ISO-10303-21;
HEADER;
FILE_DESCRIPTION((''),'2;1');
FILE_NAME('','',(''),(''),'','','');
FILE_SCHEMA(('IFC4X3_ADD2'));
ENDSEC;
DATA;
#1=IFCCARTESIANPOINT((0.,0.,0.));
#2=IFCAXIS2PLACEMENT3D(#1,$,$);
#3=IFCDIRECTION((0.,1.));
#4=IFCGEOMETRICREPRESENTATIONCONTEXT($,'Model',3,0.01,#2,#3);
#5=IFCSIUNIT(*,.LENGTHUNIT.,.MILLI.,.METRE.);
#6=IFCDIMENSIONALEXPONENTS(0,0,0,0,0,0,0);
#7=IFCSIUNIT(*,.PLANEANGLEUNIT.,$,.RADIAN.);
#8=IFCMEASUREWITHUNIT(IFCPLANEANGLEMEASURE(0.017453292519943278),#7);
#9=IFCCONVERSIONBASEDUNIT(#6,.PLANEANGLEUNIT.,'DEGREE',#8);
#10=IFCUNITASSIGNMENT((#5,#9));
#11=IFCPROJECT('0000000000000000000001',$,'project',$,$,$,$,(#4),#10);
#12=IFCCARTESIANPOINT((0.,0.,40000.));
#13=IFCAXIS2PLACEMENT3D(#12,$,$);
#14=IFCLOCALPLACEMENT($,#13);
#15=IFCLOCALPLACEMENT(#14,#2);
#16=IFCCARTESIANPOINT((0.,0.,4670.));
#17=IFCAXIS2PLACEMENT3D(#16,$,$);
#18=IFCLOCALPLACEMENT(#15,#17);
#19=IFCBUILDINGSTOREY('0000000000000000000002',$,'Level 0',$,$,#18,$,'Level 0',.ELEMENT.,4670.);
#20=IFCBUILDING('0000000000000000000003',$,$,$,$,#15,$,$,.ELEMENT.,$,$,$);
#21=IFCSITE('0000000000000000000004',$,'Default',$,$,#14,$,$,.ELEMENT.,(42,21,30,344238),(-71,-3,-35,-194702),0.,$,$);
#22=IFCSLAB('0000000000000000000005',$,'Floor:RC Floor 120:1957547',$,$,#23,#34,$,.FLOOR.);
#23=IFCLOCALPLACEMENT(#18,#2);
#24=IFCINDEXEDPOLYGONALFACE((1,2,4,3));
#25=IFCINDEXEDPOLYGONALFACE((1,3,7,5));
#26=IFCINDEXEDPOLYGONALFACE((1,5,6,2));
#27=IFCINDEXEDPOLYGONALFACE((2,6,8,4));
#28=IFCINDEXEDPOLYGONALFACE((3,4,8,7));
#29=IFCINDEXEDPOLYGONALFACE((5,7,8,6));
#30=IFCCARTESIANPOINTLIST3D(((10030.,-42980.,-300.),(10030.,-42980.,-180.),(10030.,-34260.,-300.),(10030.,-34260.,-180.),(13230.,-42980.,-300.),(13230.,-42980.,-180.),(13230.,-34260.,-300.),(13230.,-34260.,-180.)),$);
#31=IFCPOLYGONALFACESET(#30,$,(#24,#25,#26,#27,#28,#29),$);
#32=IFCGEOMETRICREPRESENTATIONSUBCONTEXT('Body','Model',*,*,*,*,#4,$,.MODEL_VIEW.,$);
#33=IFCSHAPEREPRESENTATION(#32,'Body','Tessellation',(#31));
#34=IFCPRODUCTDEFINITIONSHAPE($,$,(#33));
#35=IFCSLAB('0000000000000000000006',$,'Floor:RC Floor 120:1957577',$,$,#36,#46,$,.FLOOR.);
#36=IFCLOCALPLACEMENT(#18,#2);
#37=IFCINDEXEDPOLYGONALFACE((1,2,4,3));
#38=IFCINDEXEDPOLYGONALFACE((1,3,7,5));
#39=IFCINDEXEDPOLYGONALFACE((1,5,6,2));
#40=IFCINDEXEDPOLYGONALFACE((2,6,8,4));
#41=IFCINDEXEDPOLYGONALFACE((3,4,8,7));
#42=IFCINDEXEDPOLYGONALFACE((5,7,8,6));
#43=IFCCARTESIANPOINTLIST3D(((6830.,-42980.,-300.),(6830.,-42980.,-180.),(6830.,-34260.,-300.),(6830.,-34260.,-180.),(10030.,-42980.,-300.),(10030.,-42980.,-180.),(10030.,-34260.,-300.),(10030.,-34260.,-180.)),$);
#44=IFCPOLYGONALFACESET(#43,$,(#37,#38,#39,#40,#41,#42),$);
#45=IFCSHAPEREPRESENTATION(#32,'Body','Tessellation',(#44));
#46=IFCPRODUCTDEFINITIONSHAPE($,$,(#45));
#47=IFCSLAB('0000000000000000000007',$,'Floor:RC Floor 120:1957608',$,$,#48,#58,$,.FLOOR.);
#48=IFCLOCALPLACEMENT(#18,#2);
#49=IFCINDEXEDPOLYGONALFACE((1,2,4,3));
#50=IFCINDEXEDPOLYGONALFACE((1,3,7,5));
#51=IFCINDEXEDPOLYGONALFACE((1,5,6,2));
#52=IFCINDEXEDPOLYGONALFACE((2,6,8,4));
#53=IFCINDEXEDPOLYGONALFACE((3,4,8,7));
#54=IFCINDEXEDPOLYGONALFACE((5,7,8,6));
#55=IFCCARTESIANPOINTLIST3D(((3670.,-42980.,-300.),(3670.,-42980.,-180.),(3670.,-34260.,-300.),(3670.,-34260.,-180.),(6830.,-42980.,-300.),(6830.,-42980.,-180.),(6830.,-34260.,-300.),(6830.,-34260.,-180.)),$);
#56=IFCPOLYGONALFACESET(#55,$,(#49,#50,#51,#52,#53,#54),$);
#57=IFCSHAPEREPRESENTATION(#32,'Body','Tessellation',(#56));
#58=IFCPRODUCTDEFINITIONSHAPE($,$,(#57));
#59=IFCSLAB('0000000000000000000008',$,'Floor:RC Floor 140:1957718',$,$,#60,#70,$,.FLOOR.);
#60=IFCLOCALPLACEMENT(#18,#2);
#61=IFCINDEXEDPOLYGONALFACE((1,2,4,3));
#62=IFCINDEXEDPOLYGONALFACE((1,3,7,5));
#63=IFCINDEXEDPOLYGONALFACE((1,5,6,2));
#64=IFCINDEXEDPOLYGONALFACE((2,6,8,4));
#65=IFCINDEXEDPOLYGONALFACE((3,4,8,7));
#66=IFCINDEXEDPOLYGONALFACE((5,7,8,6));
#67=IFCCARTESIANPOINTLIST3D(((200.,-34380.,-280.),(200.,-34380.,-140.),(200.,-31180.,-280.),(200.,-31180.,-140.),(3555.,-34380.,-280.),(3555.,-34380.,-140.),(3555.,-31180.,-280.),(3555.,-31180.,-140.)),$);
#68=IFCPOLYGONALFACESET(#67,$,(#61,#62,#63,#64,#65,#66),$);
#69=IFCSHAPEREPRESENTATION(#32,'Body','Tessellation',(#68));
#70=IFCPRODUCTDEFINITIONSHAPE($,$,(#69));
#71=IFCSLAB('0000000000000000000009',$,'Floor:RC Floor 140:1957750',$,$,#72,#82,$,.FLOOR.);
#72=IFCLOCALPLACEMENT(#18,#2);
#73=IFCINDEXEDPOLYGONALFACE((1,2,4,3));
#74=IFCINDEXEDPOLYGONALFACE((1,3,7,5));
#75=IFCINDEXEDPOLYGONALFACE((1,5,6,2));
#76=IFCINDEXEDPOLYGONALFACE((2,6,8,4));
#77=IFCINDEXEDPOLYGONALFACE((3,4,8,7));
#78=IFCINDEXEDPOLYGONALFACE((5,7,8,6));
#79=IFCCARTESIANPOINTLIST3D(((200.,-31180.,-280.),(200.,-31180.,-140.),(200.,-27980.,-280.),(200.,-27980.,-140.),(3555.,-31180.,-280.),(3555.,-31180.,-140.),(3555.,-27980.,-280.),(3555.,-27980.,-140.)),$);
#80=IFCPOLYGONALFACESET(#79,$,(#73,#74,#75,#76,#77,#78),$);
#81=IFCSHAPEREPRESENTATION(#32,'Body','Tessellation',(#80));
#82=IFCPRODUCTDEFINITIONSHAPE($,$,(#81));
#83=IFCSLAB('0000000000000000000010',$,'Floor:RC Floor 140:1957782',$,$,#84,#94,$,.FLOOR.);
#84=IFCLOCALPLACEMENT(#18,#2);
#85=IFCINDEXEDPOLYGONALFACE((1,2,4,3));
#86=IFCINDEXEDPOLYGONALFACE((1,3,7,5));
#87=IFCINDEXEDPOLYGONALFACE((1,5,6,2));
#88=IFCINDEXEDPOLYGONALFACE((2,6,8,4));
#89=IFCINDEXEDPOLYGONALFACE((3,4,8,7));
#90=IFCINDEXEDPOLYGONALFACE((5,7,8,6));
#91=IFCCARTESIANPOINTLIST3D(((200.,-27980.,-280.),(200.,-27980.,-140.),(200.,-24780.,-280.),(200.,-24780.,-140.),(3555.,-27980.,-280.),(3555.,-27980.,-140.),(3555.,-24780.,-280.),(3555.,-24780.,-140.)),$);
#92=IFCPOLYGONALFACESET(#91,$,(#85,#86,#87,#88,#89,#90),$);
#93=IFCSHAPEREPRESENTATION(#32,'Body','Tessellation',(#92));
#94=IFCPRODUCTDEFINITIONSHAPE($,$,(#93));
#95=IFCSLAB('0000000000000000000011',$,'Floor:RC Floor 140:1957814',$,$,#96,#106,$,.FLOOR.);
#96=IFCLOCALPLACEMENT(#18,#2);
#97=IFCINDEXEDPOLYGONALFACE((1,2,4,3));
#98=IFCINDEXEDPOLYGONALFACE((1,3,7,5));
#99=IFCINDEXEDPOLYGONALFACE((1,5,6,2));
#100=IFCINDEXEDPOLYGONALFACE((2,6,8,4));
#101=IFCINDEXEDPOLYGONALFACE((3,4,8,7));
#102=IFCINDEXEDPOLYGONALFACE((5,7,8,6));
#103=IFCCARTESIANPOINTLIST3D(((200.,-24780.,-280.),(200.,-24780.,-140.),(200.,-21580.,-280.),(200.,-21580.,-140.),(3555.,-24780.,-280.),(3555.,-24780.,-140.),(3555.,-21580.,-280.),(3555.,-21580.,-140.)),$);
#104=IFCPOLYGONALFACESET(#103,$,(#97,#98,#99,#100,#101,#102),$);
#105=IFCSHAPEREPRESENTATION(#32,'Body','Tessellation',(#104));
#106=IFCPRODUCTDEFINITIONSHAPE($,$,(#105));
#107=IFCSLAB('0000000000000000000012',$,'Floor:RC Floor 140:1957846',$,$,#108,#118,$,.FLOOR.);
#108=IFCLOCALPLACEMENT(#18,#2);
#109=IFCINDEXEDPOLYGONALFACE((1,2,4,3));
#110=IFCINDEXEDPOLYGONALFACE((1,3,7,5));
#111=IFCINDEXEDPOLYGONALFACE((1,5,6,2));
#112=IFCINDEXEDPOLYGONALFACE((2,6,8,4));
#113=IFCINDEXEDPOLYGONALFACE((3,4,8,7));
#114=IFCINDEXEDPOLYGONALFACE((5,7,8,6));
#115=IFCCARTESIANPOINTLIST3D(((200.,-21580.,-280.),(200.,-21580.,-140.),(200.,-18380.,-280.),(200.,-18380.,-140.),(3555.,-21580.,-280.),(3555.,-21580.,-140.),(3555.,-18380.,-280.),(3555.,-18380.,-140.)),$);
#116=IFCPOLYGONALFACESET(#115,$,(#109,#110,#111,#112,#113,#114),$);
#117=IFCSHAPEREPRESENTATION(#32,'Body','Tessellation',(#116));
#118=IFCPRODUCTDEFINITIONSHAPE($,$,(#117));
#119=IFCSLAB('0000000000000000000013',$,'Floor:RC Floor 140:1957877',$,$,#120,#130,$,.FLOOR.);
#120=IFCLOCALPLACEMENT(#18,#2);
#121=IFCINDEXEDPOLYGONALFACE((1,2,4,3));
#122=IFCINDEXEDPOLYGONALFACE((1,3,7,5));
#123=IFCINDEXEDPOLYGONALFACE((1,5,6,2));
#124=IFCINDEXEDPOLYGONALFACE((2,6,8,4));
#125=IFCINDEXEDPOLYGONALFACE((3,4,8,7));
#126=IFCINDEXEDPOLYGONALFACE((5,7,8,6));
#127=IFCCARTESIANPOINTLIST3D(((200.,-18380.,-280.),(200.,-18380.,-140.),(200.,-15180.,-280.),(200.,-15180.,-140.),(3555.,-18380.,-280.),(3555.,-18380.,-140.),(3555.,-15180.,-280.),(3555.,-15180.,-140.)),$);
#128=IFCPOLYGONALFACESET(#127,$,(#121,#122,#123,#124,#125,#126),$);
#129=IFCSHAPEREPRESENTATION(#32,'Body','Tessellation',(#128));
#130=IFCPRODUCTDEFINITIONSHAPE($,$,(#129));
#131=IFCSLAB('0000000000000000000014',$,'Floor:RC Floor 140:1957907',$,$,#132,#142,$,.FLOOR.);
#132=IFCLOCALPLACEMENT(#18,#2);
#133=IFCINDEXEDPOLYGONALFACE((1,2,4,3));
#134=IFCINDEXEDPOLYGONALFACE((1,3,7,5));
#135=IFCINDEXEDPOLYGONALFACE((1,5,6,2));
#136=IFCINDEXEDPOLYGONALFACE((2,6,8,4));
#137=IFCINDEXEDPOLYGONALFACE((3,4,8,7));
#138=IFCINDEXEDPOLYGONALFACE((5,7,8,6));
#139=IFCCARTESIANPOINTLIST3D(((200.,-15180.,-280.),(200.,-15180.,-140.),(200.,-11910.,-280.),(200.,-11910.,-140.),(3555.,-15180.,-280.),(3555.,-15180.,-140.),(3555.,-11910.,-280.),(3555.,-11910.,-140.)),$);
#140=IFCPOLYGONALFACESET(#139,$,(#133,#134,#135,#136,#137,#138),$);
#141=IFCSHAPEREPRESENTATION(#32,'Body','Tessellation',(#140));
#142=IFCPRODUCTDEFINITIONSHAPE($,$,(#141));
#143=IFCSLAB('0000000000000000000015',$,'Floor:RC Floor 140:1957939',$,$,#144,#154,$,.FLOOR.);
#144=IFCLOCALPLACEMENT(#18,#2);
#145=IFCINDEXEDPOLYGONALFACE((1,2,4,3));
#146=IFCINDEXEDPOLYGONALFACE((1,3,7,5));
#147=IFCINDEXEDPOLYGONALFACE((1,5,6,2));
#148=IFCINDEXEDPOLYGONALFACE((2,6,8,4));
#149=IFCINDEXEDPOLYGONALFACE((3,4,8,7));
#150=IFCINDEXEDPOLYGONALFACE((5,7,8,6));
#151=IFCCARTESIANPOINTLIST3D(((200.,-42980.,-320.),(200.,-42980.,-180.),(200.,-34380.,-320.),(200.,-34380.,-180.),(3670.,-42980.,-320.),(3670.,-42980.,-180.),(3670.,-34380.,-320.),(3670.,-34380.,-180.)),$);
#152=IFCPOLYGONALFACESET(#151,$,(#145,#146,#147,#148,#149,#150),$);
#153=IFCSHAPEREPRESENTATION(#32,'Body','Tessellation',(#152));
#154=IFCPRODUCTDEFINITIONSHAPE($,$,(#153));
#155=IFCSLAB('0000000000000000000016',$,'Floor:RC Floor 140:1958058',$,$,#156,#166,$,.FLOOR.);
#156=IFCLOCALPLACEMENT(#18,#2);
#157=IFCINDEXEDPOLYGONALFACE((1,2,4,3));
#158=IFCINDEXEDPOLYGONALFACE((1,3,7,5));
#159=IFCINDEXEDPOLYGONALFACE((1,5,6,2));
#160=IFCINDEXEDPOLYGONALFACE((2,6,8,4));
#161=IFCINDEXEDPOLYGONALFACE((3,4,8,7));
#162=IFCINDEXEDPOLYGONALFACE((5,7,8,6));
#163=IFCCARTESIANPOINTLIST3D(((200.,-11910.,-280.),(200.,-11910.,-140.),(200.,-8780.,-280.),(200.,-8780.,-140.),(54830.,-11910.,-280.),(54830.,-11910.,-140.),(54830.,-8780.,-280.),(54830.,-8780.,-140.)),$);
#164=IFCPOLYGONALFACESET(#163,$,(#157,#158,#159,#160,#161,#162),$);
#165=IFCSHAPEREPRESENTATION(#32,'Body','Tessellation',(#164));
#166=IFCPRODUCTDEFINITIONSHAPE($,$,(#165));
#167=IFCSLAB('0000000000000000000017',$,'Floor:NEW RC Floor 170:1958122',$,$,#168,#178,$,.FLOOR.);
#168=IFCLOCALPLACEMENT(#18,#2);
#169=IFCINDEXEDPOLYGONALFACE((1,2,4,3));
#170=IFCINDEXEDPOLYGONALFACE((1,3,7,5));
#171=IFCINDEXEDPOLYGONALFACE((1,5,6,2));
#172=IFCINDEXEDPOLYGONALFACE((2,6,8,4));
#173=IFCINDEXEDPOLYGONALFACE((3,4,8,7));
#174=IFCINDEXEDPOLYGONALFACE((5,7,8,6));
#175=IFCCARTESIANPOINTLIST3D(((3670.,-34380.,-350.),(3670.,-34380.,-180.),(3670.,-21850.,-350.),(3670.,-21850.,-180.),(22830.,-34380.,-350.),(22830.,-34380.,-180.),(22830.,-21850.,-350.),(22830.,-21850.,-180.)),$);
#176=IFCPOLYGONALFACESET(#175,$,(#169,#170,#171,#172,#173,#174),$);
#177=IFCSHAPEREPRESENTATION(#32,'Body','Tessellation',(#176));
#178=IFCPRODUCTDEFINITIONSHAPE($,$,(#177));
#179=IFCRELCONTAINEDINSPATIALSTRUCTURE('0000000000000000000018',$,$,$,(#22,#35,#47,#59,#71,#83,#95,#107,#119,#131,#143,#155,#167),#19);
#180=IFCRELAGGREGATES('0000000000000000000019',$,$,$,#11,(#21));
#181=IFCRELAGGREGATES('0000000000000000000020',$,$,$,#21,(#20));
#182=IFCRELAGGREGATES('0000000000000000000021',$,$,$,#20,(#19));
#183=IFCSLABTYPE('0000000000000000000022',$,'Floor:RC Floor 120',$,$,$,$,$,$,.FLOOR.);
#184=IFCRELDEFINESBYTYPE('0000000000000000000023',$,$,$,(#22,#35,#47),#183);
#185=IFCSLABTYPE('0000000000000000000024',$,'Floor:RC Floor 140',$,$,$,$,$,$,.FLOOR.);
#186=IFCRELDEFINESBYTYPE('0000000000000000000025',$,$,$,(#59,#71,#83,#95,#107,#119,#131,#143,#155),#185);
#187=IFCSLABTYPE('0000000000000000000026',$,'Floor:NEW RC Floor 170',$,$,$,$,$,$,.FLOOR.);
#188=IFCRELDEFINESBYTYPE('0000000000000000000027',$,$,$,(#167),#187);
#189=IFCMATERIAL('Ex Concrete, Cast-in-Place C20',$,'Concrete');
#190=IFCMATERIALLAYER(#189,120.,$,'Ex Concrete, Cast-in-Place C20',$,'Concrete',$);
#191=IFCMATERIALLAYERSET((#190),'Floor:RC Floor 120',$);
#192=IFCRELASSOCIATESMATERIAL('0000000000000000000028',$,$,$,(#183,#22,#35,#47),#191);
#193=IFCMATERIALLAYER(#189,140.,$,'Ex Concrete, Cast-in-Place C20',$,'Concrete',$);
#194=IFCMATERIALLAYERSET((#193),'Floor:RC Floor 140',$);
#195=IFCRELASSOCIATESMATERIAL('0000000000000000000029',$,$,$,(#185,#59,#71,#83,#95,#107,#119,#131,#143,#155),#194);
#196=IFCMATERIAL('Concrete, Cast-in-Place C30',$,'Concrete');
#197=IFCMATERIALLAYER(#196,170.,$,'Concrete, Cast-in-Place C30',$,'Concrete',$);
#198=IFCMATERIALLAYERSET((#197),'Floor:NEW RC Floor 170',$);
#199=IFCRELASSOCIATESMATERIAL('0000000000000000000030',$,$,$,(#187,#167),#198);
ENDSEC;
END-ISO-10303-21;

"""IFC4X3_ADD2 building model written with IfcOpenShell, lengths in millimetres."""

from ifc_helpers import new_model, entity, si_unit, converted_unit, direction, frame, frame_2d, origin, origin_2d_with_axis, place, context, subcontext, project, spatial, rectangle, extrude, material, layer, layer_set, layer_usage, type_object, element, save


model = new_model("IFC4X3_ADD2")

# Units and contexts
model_context = context("Model", 3, precision=0.01, world=origin(), true_north=direction((0.0, 1.0)))
body_context = subcontext(model_context, "Body", "Model", "MODEL_VIEW")
ifc_project = project(units=[si_unit("LENGTHUNIT", "METRE", prefix="MILLI"), converted_unit("PLANEANGLEUNIT", "DEGREE", entity("IfcPlaneAngleMeasure", 0.017453292519943278), si_unit("PLANEANGLEUNIT", "RADIAN"), dimensions=[0, 0, 0, 0, 0, 0, 0])], contexts=[model_context])

# Site, building, storey
site_placement = place(None, frame((0.0, 0.0, 40000.0)))
site = spatial("IfcSite", under=ifc_project, at=site_placement, Name="Default", CompositionType="ELEMENT", RefLatitude=(42, 21, 30, 344238), RefLongitude=(-71, -3, -35, -194702), RefElevation=0.0)
building_placement = place(site_placement, origin())
building = spatial("IfcBuilding", under=site, at=building_placement, CompositionType="ELEMENT")
storey_placement = place(building_placement, frame((0.0, 0.0, 4670.0)))
storey = spatial("IfcBuildingStorey", under=building, at=storey_placement, Name="Level 0", LongName="Level 0", CompositionType="ELEMENT", Elevation=4670.0)

# Slabs
ifc_material_1 = material(Name="Ex Concrete, Cast-in-Place C20", Category="Concrete")
ifc_layer_1 = layer(ifc_material_1, 120.0, Name="Ex Concrete, Cast-in-Place C20", Category="Concrete")
ifc_layer_set_1 = layer_set([ifc_layer_1], Name="Floor:RC Floor 120")
slab_type_1 = type_object("IfcSlabType", Name="Floor:RC Floor 120", PredefinedType="FLOOR", material=ifc_layer_set_1)
ifc_layer_usage_1 = layer_usage(ifc_layer_set_1, "AXIS3", "POSITIVE", 0.0)
slab_1_placement = place(storey_placement, origin())
element("IfcSlab", 1, at=slab_1_placement, inside=storey, type_object=slab_type_1, material=ifc_layer_usage_1, Name="Floor:RC Floor 120:1957547", PredefinedType="FLOOR", context=body_context, shape_type="SweptSolid", body=[
    extrude(rectangle(XDim=8720.0, YDim=3200.0, at=frame_2d((0.0, 0.0), x_axis=(1.0, 0.0))), frame((11630.0, -38620.0, -180.0), z_axis=(0.0, 0.0, -1.0), x_axis=(0.0, 1.0, 0.0)), (0.0, 0.0, 1.0), 120.0),
])
ifc_layer_usage_2 = layer_usage(ifc_layer_set_1, "AXIS3", "POSITIVE", 0.0)
slab_2_placement = place(storey_placement, origin())
element("IfcSlab", 2, at=slab_2_placement, inside=storey, type_object=slab_type_1, material=ifc_layer_usage_2, Name="Floor:RC Floor 120:1957577", PredefinedType="FLOOR", context=body_context, shape_type="SweptSolid", body=[
    extrude(rectangle(XDim=8720.0, YDim=3200.0, at=frame_2d((0.0, 0.0), x_axis=(1.0, 0.0))), frame((8430.0, -38620.0, -180.0), z_axis=(0.0, 0.0, -1.0), x_axis=(0.0, 1.0, 0.0)), (0.0, 0.0, 1.0), 120.0),
])
ifc_layer_usage_3 = layer_usage(ifc_layer_set_1, "AXIS3", "POSITIVE", 0.0)
slab_3_placement = place(storey_placement, origin())
element("IfcSlab", 3, at=slab_3_placement, inside=storey, type_object=slab_type_1, material=ifc_layer_usage_3, Name="Floor:RC Floor 120:1957608", PredefinedType="FLOOR", context=body_context, shape_type="SweptSolid", body=[
    extrude(rectangle(XDim=8720.0, YDim=3160.0, at=frame_2d((0.0, 0.0), x_axis=(1.0, 0.0))), frame((5250.0, -38620.0, -180.0), z_axis=(0.0, 0.0, -1.0), x_axis=(0.0, 1.0, 0.0)), (0.0, 0.0, 1.0), 120.0),
])
ifc_layer_2 = layer(ifc_material_1, 140.0, Name="Ex Concrete, Cast-in-Place C20", Category="Concrete")
ifc_layer_set_2 = layer_set([ifc_layer_2], Name="Floor:RC Floor 140")
ifc_layer_usage_4 = layer_usage(ifc_layer_set_2, "AXIS3", "POSITIVE", 0.0)
slab_type_2 = type_object("IfcSlabType", Name="Floor:RC Floor 140", PredefinedType="FLOOR", material=ifc_layer_set_2)
slab_4_placement = place(storey_placement, origin())
element("IfcSlab", 4, at=slab_4_placement, inside=storey, type_object=slab_type_2, material=ifc_layer_usage_4, Name="Floor:RC Floor 140:1957718", PredefinedType="FLOOR", context=body_context, shape_type="SweptSolid", body=[
    extrude(rectangle(XDim=3200.0, YDim=3355.0, at=frame_2d((0.0, 0.0), x_axis=(1.0, 0.0))), frame((1877.5, -32780.0, -140.0), z_axis=(0.0, 0.0, -1.0), x_axis=(0.0, 1.0, 0.0)), (0.0, 0.0, 1.0), 140.0),
])
ifc_layer_usage_5 = layer_usage(ifc_layer_set_2, "AXIS3", "POSITIVE", 0.0)
slab_5_placement = place(storey_placement, origin())
element("IfcSlab", 5, at=slab_5_placement, inside=storey, type_object=slab_type_2, material=ifc_layer_usage_5, Name="Floor:RC Floor 140:1957750", PredefinedType="FLOOR", context=body_context, shape_type="SweptSolid", body=[
    extrude(rectangle(XDim=3200.0, YDim=3355.0, at=origin_2d_with_axis()), frame((1877.5, -29580.0, -140.0), z_axis=(0.0, 0.0, -1.0), x_axis=(0.0, 1.0, 0.0)), (0.0, 0.0, 1.0), 140.0),
])
ifc_layer_usage_6 = layer_usage(ifc_layer_set_2, "AXIS3", "POSITIVE", 0.0)
slab_6_placement = place(storey_placement, origin())
element("IfcSlab", 6, at=slab_6_placement, inside=storey, type_object=slab_type_2, material=ifc_layer_usage_6, Name="Floor:RC Floor 140:1957782", PredefinedType="FLOOR", context=body_context, shape_type="SweptSolid", body=[
    extrude(rectangle(XDim=3200.0, YDim=3355.0, at=origin_2d_with_axis()), frame((1877.5, -26380.0, -140.0), z_axis=(0.0, 0.0, -1.0), x_axis=(0.0, 1.0, 0.0)), (0.0, 0.0, 1.0), 140.0),
])
ifc_layer_usage_7 = layer_usage(ifc_layer_set_2, "AXIS3", "POSITIVE", 0.0)
slab_7_placement = place(storey_placement, origin())
element("IfcSlab", 7, at=slab_7_placement, inside=storey, type_object=slab_type_2, material=ifc_layer_usage_7, Name="Floor:RC Floor 140:1957814", PredefinedType="FLOOR", context=body_context, shape_type="SweptSolid", body=[
    extrude(rectangle(XDim=3200.0, YDim=3355.0, at=origin_2d_with_axis()), frame((1877.5, -23180.0, -140.0), z_axis=(0.0, 0.0, -1.0), x_axis=(0.0, 1.0, 0.0)), (0.0, 0.0, 1.0), 140.0),
])
ifc_layer_usage_8 = layer_usage(ifc_layer_set_2, "AXIS3", "POSITIVE", 0.0)
slab_8_placement = place(storey_placement, origin())
element("IfcSlab", 8, at=slab_8_placement, inside=storey, type_object=slab_type_2, material=ifc_layer_usage_8, Name="Floor:RC Floor 140:1957846", PredefinedType="FLOOR", context=body_context, shape_type="SweptSolid", body=[
    extrude(rectangle(XDim=3200.0, YDim=3355.0, at=frame_2d((0.0, 0.0), x_axis=(1.0, 0.0))), frame((1877.5, -19980.0, -140.0), z_axis=(0.0, 0.0, -1.0), x_axis=(0.0, 1.0, 0.0)), (0.0, 0.0, 1.0), 140.0),
])
ifc_layer_usage_9 = layer_usage(ifc_layer_set_2, "AXIS3", "POSITIVE", 0.0)
slab_9_placement = place(storey_placement, origin())
element("IfcSlab", 9, at=slab_9_placement, inside=storey, type_object=slab_type_2, material=ifc_layer_usage_9, Name="Floor:RC Floor 140:1957877", PredefinedType="FLOOR", context=body_context, shape_type="SweptSolid", body=[
    extrude(rectangle(XDim=3200.0, YDim=3355.0, at=frame_2d((0.0, 0.0), x_axis=(1.0, 0.0))), frame((1877.5, -16780.0, -140.0), z_axis=(0.0, 0.0, -1.0), x_axis=(0.0, 1.0, 0.0)), (0.0, 0.0, 1.0), 140.0),
])
ifc_layer_usage_10 = layer_usage(ifc_layer_set_2, "AXIS3", "POSITIVE", 0.0)
slab_10_placement = place(storey_placement, origin())
element("IfcSlab", 10, at=slab_10_placement, inside=storey, type_object=slab_type_2, material=ifc_layer_usage_10, Name="Floor:RC Floor 140:1957907", PredefinedType="FLOOR", context=body_context, shape_type="SweptSolid", body=[
    extrude(rectangle(XDim=3270.0, YDim=3355.0, at=origin_2d_with_axis()), frame((1877.5, -13545.0, -140.0), z_axis=(0.0, 0.0, -1.0), x_axis=(0.0, 1.0, 0.0)), (0.0, 0.0, 1.0), 140.0),
])
ifc_layer_usage_11 = layer_usage(ifc_layer_set_2, "AXIS3", "POSITIVE", 0.0)
slab_11_placement = place(storey_placement, origin())
element("IfcSlab", 11, at=slab_11_placement, inside=storey, type_object=slab_type_2, material=ifc_layer_usage_11, Name="Floor:RC Floor 140:1957939", PredefinedType="FLOOR", context=body_context, shape_type="SweptSolid", body=[
    extrude(rectangle(XDim=8600.0, YDim=3470.0, at=frame_2d((0.0, 0.0), x_axis=(1.0, 0.0))), frame((1935.0, -38680.0, -180.0), z_axis=(0.0, 0.0, -1.0), x_axis=(0.0, 1.0, 0.0)), (0.0, 0.0, 1.0), 140.0),
])
ifc_layer_usage_12 = layer_usage(ifc_layer_set_2, "AXIS3", "POSITIVE", 0.0)
slab_12_placement = place(storey_placement, origin())
element("IfcSlab", 12, at=slab_12_placement, inside=storey, type_object=slab_type_2, material=ifc_layer_usage_12, Name="Floor:RC Floor 140:1958058", PredefinedType="FLOOR", context=body_context, shape_type="SweptSolid", body=[
    extrude(rectangle(XDim=3130.0, YDim=54630.0, at=frame_2d((0.0, 0.0), x_axis=(1.0, 0.0))), frame((27515.0, -10345.0, -140.0), z_axis=(0.0, 0.0, -1.0), x_axis=(0.0, 1.0, 0.0)), (0.0, 0.0, 1.0), 140.0),
])
ifc_material_2 = material(Name="Concrete, Cast-in-Place C30", Category="Concrete")
ifc_layer_3 = layer(ifc_material_2, 170.0, Name="Concrete, Cast-in-Place C30", Category="Concrete")
ifc_layer_set_3 = layer_set([ifc_layer_3], Name="Floor:NEW RC Floor 170")
ifc_layer_usage_13 = layer_usage(ifc_layer_set_3, "AXIS3", "POSITIVE", 0.0)
slab_type_3 = type_object("IfcSlabType", Name="Floor:NEW RC Floor 170", PredefinedType="FLOOR", material=ifc_layer_set_3)
slab_13_placement = place(storey_placement, origin())
element("IfcSlab", 13, at=slab_13_placement, inside=storey, type_object=slab_type_3, material=ifc_layer_usage_13, Name="Floor:NEW RC Floor 170:1958122", PredefinedType="FLOOR", context=body_context, shape_type="SweptSolid", body=[
    extrude(rectangle(XDim=12530.0, YDim=19160.0, at=frame_2d((0.0, 0.0), x_axis=(1.0, 0.0))), frame((13250.0, -28115.0, -180.0), z_axis=(0.0, 0.0, -1.0), x_axis=(0.0, 1.0, 0.0)), (0.0, 0.0, 1.0), 170.0),
])

save(model, "model.ifc")
